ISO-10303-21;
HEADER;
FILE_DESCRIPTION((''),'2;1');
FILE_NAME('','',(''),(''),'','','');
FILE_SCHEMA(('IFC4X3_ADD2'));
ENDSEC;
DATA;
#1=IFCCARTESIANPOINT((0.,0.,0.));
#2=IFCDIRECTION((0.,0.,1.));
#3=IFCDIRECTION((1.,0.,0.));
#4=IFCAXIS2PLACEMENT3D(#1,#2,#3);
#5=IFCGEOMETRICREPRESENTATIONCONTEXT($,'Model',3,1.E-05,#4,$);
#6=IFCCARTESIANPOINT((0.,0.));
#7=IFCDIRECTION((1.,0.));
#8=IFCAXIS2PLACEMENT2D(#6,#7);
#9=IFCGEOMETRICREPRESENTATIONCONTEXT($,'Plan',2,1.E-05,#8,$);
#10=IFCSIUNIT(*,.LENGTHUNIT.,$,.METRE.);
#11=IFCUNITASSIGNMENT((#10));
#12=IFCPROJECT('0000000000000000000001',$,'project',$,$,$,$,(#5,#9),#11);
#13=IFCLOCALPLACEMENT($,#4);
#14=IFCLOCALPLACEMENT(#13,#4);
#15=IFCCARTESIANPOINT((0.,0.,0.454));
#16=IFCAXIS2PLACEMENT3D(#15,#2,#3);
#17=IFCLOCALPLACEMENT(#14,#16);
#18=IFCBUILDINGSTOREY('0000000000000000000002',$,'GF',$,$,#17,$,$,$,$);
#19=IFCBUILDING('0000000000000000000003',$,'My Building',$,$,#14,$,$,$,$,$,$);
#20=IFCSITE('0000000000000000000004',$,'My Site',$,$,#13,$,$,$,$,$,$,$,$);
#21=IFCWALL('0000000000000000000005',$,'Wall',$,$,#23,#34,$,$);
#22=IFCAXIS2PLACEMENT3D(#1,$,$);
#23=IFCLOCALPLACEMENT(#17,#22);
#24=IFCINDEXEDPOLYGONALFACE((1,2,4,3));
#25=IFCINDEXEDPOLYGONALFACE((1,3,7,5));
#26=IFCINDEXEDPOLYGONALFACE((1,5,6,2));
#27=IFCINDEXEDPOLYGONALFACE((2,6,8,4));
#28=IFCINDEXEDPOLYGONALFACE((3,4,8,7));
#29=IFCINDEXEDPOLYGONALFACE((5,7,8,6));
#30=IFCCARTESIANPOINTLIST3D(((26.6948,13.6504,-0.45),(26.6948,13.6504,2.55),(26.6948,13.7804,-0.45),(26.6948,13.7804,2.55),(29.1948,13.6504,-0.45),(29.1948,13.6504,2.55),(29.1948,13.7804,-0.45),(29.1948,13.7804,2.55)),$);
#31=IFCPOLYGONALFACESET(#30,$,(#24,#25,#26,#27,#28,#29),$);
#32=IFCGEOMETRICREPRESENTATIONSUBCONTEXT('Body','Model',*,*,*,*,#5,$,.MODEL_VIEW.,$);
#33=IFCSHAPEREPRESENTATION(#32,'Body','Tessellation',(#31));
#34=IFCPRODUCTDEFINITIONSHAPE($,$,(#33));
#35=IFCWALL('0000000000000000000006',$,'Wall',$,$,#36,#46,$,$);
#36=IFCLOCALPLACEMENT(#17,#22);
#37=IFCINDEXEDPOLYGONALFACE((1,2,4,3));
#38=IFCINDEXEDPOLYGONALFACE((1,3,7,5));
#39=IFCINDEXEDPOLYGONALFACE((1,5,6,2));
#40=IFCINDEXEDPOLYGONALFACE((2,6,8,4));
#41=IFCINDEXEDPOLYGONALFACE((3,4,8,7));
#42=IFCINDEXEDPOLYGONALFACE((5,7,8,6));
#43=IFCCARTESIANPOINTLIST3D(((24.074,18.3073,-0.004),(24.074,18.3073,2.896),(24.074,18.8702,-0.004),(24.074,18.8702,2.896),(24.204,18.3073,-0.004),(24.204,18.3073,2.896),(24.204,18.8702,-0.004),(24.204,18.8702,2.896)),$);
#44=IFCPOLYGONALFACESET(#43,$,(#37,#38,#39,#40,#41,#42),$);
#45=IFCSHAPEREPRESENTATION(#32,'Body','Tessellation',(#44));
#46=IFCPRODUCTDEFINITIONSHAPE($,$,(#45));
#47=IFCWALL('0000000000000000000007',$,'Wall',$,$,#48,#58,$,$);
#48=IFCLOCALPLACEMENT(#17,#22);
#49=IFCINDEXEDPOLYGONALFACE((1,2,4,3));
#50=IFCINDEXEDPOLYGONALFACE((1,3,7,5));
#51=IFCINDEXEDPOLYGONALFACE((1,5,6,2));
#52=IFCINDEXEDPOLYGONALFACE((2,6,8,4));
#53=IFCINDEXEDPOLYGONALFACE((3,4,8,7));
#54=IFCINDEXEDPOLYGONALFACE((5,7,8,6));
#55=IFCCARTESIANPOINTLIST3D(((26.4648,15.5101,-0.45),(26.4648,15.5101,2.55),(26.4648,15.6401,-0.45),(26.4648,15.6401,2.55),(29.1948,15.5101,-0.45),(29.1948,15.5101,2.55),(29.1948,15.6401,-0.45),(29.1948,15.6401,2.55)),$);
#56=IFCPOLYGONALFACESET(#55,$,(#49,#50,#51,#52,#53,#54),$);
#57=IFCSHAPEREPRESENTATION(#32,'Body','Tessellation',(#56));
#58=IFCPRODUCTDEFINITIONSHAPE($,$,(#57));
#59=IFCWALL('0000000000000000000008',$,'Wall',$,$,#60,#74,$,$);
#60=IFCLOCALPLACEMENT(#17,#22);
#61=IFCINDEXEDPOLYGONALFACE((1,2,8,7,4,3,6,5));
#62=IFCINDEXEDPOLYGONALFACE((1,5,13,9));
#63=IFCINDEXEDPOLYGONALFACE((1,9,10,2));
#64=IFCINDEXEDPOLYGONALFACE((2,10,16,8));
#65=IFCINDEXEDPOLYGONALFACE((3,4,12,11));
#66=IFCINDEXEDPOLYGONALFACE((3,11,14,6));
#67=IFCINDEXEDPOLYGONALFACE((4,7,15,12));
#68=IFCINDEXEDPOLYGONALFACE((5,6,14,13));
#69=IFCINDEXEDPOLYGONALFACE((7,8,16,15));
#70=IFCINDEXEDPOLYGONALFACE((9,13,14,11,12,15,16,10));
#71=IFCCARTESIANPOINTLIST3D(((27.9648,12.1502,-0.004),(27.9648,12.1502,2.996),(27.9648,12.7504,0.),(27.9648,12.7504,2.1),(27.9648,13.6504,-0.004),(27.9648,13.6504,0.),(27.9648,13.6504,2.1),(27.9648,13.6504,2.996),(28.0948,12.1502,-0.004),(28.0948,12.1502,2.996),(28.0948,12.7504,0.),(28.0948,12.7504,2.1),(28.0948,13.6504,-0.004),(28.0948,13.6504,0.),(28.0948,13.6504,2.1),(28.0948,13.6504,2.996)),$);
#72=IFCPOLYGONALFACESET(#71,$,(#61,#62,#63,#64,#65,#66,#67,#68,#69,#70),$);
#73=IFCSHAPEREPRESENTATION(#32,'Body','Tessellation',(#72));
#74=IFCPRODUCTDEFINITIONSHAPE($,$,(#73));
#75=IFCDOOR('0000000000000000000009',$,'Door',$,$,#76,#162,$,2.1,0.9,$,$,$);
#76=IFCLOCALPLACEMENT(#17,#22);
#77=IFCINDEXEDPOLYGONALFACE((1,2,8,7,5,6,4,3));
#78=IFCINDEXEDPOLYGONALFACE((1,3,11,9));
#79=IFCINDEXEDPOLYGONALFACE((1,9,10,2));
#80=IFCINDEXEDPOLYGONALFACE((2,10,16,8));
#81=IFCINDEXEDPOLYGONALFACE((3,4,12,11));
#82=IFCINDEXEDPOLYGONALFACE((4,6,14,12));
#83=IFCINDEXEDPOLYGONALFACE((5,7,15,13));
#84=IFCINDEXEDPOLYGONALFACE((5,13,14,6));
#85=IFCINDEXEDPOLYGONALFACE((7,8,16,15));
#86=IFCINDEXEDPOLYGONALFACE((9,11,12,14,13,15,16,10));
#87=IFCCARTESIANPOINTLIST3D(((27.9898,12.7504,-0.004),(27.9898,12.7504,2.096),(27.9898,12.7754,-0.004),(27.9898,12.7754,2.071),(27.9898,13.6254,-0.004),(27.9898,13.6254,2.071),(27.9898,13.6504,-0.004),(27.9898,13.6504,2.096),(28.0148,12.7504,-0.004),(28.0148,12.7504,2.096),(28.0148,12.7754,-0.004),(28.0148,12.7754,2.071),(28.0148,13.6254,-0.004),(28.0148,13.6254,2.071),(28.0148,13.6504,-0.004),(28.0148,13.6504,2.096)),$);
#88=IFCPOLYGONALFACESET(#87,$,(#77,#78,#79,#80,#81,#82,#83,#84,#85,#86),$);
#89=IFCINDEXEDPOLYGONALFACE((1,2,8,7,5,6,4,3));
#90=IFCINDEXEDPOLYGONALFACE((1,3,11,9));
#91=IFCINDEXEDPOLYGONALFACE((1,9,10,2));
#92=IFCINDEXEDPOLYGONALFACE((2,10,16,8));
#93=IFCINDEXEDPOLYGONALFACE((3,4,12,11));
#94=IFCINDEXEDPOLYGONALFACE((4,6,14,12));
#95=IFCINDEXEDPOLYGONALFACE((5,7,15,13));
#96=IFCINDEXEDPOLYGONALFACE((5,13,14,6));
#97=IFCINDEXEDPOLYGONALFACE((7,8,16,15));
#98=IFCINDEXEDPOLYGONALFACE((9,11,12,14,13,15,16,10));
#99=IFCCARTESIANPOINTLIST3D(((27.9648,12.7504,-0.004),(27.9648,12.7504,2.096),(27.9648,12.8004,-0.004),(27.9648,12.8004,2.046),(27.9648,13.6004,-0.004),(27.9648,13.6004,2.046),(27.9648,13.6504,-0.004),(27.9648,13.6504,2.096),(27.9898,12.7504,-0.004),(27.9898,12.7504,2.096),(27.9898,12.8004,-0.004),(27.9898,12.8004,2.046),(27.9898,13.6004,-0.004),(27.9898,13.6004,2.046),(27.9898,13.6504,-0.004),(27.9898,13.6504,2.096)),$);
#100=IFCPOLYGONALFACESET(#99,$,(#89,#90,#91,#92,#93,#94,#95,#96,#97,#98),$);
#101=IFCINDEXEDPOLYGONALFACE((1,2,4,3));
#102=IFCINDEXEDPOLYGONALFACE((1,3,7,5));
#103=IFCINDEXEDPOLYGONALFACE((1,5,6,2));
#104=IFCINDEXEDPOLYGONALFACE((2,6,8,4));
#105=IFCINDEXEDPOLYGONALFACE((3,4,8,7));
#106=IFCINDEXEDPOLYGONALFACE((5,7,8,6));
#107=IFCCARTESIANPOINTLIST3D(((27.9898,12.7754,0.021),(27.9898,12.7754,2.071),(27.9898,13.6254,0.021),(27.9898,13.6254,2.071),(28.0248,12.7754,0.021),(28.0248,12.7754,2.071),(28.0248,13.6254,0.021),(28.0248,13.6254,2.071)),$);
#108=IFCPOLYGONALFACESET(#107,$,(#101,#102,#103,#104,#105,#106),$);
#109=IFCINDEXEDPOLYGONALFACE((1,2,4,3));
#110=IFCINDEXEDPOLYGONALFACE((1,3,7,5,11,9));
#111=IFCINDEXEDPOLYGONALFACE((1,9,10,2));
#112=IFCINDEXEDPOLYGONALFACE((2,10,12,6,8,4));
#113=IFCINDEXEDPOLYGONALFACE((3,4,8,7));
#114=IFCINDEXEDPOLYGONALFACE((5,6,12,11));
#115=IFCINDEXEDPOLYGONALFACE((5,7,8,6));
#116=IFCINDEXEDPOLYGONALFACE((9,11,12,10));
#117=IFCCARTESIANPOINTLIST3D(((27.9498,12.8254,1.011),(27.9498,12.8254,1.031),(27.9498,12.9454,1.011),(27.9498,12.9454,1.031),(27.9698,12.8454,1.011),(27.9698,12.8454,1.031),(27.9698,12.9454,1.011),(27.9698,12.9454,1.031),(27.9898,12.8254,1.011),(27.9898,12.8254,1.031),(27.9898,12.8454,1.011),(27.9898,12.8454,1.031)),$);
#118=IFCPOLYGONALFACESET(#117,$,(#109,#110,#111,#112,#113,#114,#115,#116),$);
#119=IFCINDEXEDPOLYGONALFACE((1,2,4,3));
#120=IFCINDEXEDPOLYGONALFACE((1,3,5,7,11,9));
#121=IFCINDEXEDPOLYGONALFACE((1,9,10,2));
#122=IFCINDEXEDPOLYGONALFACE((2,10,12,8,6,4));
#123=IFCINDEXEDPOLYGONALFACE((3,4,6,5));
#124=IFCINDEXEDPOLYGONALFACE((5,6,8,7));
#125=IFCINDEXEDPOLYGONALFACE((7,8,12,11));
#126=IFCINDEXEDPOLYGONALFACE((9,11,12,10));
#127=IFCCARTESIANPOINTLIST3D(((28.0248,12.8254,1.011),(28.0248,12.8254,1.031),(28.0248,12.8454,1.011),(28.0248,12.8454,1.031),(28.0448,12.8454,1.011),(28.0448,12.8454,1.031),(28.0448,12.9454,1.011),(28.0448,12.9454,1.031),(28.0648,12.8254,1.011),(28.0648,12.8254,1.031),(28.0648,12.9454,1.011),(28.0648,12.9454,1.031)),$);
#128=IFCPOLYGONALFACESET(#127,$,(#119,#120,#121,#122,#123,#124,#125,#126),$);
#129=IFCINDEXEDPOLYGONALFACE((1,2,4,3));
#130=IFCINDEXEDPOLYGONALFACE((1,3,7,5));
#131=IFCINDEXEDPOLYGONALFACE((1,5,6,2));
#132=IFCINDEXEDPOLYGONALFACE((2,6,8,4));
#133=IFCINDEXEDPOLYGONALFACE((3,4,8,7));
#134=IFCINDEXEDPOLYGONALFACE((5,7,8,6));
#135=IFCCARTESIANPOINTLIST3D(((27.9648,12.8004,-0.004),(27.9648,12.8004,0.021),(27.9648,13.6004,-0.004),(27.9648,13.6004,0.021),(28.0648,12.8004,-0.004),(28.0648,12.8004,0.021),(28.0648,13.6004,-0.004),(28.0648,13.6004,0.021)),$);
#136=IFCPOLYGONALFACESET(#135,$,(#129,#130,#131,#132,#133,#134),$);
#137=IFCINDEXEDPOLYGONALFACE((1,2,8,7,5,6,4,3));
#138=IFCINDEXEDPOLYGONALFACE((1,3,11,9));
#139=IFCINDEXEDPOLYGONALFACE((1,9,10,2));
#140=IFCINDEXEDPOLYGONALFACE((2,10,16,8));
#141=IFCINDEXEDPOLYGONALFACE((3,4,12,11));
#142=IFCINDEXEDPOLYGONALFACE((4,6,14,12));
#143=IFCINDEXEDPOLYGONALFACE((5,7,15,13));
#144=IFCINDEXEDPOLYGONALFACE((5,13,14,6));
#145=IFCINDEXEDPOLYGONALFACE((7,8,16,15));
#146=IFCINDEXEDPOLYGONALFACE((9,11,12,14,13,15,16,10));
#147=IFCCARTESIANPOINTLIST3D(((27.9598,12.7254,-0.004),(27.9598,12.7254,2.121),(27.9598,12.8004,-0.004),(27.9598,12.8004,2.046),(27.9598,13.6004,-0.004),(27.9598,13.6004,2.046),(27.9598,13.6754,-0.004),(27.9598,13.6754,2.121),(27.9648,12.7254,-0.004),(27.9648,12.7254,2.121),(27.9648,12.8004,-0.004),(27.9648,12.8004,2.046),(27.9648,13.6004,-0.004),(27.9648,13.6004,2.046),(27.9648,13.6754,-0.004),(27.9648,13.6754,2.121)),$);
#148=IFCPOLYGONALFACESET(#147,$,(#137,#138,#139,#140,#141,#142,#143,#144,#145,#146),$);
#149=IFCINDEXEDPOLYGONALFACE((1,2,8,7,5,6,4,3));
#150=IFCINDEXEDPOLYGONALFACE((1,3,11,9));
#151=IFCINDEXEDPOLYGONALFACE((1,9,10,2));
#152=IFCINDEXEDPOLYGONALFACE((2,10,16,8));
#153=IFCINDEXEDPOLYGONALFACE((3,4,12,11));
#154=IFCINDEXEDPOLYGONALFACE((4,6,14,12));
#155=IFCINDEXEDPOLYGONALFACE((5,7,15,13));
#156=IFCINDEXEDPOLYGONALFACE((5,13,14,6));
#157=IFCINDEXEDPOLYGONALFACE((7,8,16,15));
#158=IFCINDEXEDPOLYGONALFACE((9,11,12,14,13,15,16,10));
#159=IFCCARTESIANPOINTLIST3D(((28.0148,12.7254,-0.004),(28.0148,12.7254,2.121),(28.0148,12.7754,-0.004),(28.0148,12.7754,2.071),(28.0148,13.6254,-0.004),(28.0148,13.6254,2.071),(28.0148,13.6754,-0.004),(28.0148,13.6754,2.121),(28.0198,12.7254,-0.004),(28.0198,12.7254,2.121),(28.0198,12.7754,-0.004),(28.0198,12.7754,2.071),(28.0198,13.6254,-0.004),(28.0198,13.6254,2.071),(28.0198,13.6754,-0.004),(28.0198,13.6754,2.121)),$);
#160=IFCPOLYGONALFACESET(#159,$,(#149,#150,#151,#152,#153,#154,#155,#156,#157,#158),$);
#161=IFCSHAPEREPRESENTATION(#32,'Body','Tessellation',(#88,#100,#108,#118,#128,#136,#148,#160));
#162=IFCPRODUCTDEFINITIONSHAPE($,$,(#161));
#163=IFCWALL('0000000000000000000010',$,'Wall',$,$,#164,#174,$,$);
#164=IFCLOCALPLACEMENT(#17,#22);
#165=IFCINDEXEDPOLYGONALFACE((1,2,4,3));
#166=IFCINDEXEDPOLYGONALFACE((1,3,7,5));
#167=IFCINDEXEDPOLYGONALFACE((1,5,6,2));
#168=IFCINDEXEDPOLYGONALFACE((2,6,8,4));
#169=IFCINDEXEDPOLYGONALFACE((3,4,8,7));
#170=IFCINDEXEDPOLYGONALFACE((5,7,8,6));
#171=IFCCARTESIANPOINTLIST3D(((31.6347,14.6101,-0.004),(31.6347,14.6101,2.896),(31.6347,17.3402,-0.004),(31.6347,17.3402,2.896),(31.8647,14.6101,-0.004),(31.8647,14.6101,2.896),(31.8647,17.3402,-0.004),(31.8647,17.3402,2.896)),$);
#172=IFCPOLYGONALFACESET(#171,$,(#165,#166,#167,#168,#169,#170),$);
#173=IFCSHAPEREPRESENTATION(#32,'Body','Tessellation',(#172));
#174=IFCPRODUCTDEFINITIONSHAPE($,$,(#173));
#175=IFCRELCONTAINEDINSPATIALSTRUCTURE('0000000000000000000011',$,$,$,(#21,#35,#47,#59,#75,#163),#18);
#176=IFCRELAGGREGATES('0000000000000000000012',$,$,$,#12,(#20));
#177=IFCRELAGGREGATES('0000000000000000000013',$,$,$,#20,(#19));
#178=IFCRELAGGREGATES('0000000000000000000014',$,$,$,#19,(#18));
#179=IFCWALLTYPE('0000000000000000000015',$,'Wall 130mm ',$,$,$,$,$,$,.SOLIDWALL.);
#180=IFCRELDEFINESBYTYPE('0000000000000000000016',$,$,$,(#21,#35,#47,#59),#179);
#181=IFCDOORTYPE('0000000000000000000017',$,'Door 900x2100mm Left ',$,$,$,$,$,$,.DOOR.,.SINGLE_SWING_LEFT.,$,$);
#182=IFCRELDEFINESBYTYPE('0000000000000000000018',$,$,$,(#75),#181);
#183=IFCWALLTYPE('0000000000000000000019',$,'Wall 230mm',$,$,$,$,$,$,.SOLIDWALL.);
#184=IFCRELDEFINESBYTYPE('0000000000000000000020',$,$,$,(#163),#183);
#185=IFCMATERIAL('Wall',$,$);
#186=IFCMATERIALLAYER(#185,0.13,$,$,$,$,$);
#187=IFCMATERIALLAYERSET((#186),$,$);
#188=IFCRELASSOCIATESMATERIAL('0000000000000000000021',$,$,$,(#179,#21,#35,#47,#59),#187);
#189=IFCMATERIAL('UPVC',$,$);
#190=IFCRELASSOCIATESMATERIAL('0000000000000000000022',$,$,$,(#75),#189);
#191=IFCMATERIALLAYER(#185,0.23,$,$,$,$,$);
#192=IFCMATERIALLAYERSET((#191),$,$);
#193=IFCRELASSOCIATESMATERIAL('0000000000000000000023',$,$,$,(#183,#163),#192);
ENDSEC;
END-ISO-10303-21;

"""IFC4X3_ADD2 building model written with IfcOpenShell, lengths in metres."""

from ifc_helpers import new_model, entity, si_unit, frame, origin_with_axes, origin_2d_with_axis, place, context, subcontext, project, spatial, line, indexed_curve, outline, extrude, shape, source, transform, mapped, material, layer, layer_set, layer_usage, type_object, type_shapes, element, fill, save


model = new_model("IFC4X3_ADD2")

# Units and contexts
model_context = context("Model", 3, precision=1e-05, world=origin_with_axes())
plan_context = context("Plan", 2, precision=1e-05, world=origin_2d_with_axis())
body_context_1 = subcontext(model_context, "Body", "Model", "MODEL_VIEW")
body_context_2 = subcontext(plan_context, "Body", "Plan", "PLAN_VIEW")
ifc_project = project(units=[si_unit("LENGTHUNIT", "METRE")], contexts=[model_context, plan_context])

# Site, building, storey
site_placement = place(None, origin_with_axes())
site = spatial("IfcSite", under=ifc_project, at=site_placement, Name="My Site")
building_placement = place(site_placement, origin_with_axes())
building = spatial("IfcBuilding", under=site, at=building_placement, Name="My Building")
storey_placement = place(building_placement, frame((0.0, 0.0, 0.454), z_axis=(0.0, 0.0, 1.0), x_axis=(1.0, 0.0, 0.0)))
storey = spatial("IfcBuildingStorey", under=building, at=storey_placement, Name="GF")

# Walls
ifc_material_1 = material(Name="Wall")
ifc_layer_1 = layer(ifc_material_1, 0.13)
ifc_layer_set_1 = layer_set([ifc_layer_1])
ifc_layer_usage_1 = layer_usage(ifc_layer_set_1, "AXIS2", "POSITIVE", 0.0)
wall_type_1 = type_object("IfcWallType", Name="Wall 130mm ", PredefinedType="SOLIDWALL", material=ifc_layer_set_1)
wall_1_placement = place(storey_placement, frame((29.1948, 13.7804, -0.45), z_axis=(0.0, 0.0, 1.0), x_axis=(-1.0, 0.0, 0.0)))
element("IfcWall", 1, at=wall_1_placement, inside=storey, type_object=wall_type_1, material=ifc_layer_usage_1, Name="Wall", context=body_context_1, shape_type="SweptSolid", body=[
    extrude(outline(indexed_curve([(0.0, 0.0), (0.0, 0.13), (2.5, 0.13), (2.5, 0.0), (0.0, 0.0)], self_intersect=False)), origin_with_axes(), (0.0, 0.0, 1.0), 3.0),
])
ifc_layer_usage_2 = layer_usage(ifc_layer_set_1, "AXIS2", "POSITIVE", 0.0)
wall_2_placement = place(storey_placement, frame((24.204, 18.3073, -0.004), z_axis=(0.0, 0.0, 1.0), x_axis=(0.000001, 1.0, 0.0)))
element("IfcWall", 2, at=wall_2_placement, inside=storey, type_object=wall_type_1, material=ifc_layer_usage_2, Name="Wall", context=body_context_1, shape_type="SweptSolid", body=[
    extrude(outline(indexed_curve([(0.0, 0.0), (0.0, 0.13), (0.5629, 0.13), (0.5629, 0.0), (0.0, 0.0)], self_intersect=False)), origin_with_axes(), (0.0, 0.0, 1.0), 2.9),
])
ifc_layer_usage_3 = layer_usage(ifc_layer_set_1, "AXIS2", "POSITIVE", 0.0)
wall_3_placement = place(storey_placement, frame((29.1948, 15.6401, -0.45), z_axis=(0.0, 0.0, 1.0), x_axis=(-1.0, 0.0, 0.0)))
element("IfcWall", 3, at=wall_3_placement, inside=storey, type_object=wall_type_1, material=ifc_layer_usage_3, Name="Wall", context=body_context_1, shape_type="SweptSolid", body=[
    extrude(outline(indexed_curve([(0.0, 0.0), (0.0, 0.13), (2.73, 0.13), (2.73, 0.0), (0.0, 0.0)], self_intersect=False)), origin_with_axes(), (0.0, 0.0, 1.0), 3.0),
])

# Wall, opening, door
ifc_layer_usage_4 = layer_usage(ifc_layer_set_1, "AXIS2", "POSITIVE", 0.0)
wall_4_placement = place(storey_placement, frame((27.9648, 13.6504, -0.004), z_axis=(0.0, 0.0, 1.0), x_axis=(0.0, -1.0, 0.0)))
wall_4 = element("IfcWall", 4, at=wall_4_placement, inside=storey, type_object=wall_type_1, material=ifc_layer_usage_4, Name="Wall", context=body_context_1, shape_type="SweptSolid", body=[
    extrude(outline(indexed_curve([(0.0, 0.0), (0.0, 0.13), (1.5002, 0.13), (1.5002, 0.0), (0.0, 0.0)], self_intersect=False)), origin_with_axes(), (0.0, 0.0, 1.0), 3.0),
])
shared_shape_1 = source(origin_with_axes(), body_context_1, "Body", "SweptSolid", [
    extrude(outline(indexed_curve([(0.0, 0.0), (0.9, 0.0), (0.9, 2.1), (0.0, 2.1)], segments=[line(1, 2, 3, 4, 1)])), frame((0.0, -0.6, 0.0), z_axis=(0.0, -1.0, 0.0), x_axis=(1.0, 0.0, 0.0)), (0.0, 0.0, -1.0), 1.2),
])
opening_1_placement = place(wall_4_placement, frame((0.0, 0.0, 0.004), z_axis=(0.0, 0.0, 1.0), x_axis=(1.0, 0.0, 0.0)))
opening_1 = element("IfcOpeningElement", 5, at=opening_1_placement, cuts=wall_4, PredefinedType="OPENING", context=body_context_1, shape_type="MappedRepresentation", body=[
    mapped(shared_shape_1, transform((0.0, 0.0, 0.0), x_axis=(1.0, 0.0, 0.0), y_axis=(0.0, 1.0, 0.0), z_axis=(0.0, 0.0, 1.0), scale=1.0)),
])
ifc_material_2 = material(Name="UPVC")
door_type_1 = type_object("IfcDoorType", Name="Door 900x2100mm Left ", OperationType="SINGLE_SWING_LEFT", PredefinedType="DOOR")
shared_shape_2 = source(origin_with_axes(), body_context_1, "Body", "SweptSolid", [
    extrude(outline(indexed_curve([(0.0, 0.0), (0.0, 2.1), (0.9, 2.1), (0.9, 0.0), (0.875, 0.0), (0.875, 2.075), (0.025, 2.075), (0.025, 0.0)], segments=[line(1, 2, 3, 4, 5, 6, 7, 8, 1)])), frame((0.0, 0.025, 0.0), z_axis=(0.0, -1.0, 0.0), x_axis=(1.0, 0.0, 0.0)), (0.0, 0.0, -1.0), 0.025),
    extrude(outline(indexed_curve([(0.0, 0.0), (0.0, 2.1), (0.9, 2.1), (0.9, 0.0), (0.85, 0.0), (0.85, 2.05), (0.05, 2.05), (0.05, 0.0)], segments=[line(1, 2, 3, 4, 5, 6, 7, 8, 1)])), frame((0.0, 0.0, 0.0), z_axis=(0.0, -1.0, 0.0), x_axis=(1.0, 0.0, 0.0)), (0.0, 0.0, -1.0), 0.025),
    extrude(outline(indexed_curve([(0.0, 0.0), (0.85, 0.0), (0.85, 0.035), (0.0, 0.035)], segments=[line(1, 2, 3, 4, 1)])), frame((0.025, 0.025, 0.025), z_axis=(0.0, 0.0, 1.0), x_axis=(1.0, 0.0, 0.0)), (0.0, 0.0, 1.0), 2.05),
    extrude(outline(indexed_curve([(0.0, 0.0), (0.0, -0.04), (-0.12, -0.04), (-0.12, -0.02), (-0.02, -0.02), (-0.02, 0.0)], segments=[line(1, 2, 3, 4, 5, 6, 1)])), frame((0.825, 0.025, 1.015), z_axis=(0.0, 0.0, 1.0), x_axis=(1.0, 0.0, 0.0)), (0.0, 0.0, 1.0), 0.02),
    extrude(outline(indexed_curve([(0.0, 0.0), (0.0, 0.04), (-0.12, 0.04), (-0.12, 0.02), (-0.02, 0.02), (-0.02, 0.0)], segments=[line(1, 2, 3, 4, 5, 6, 1)])), frame((0.825, 0.06, 1.015), z_axis=(0.0, 0.0, 1.0), x_axis=(1.0, 0.0, 0.0)), (0.0, 0.0, 1.0), 0.02),
    extrude(outline(indexed_curve([(0.0, 0.0), (0.8, 0.0), (0.8, 0.1), (0.0, 0.1)], segments=[line(1, 2, 3, 4, 1)])), frame((0.05, 0.0, 0.0), z_axis=(0.0, 0.0, 1.0), x_axis=(1.0, 0.0, 0.0)), (0.0, 0.0, 1.0), 0.025),
    extrude(outline(indexed_curve([(0.0, 0.0), (0.0, 2.125), (0.95, 2.125), (0.95, 0.0), (0.875, 0.0), (0.875, 2.05), (0.075, 2.05), (0.075, 0.0)], segments=[line(1, 2, 3, 4, 5, 6, 7, 8, 1)])), frame((-0.025, -0.005, 0.0), z_axis=(0.0, -1.0, 0.0), x_axis=(1.0, 0.0, 0.0)), (0.0, 0.0, -1.0), 0.005),
    extrude(outline(indexed_curve([(0.0, 0.0), (0.0, 2.125), (0.95, 2.125), (0.95, 0.0), (0.9, 0.0), (0.9, 2.075), (0.05, 2.075), (0.05, 0.0)], segments=[line(1, 2, 3, 4, 5, 6, 7, 8, 1)])), frame((-0.025, 0.05, 0.0), z_axis=(0.0, -1.0, 0.0), x_axis=(1.0, 0.0, 0.0)), (0.0, 0.0, -1.0), 0.005),
])
shared_shape_3 = source(origin_with_axes(), body_context_2, "Body", "Curve2D", [
    entity("IfcIndexedPolyCurve", entity("IfcCartesianPointList2D", [[0.0, 0.0], [0.0, 0.05], [0.025, 0.05], [0.025, 0.025], [0.05, 0.025], [0.05, 0.0]]), [entity("IfcLineIndex", [1, 2, 3, 4, 5, 6, 1])]),
    entity("IfcIndexedPolyCurve", entity("IfcCartesianPointList2D", [[0.9, 0.0], [0.9, 0.05], [0.875, 0.05], [0.875, 0.025], [0.85, 0.025], [0.85, 0.0]]), [entity("IfcLineIndex", [1, 2, 3, 4, 5, 6, 1])]),
    entity("IfcTrimmedCurve", entity("IfcEllipse", entity("IfcAxis2Placement2D", entity("IfcCartesianPoint", [0.06, 0.05]), entity("IfcDirection", [1.0, 0.0])), 0.815, 0.85), [entity("IfcCartesianPoint", [0.875, 0.05])], [entity("IfcCartesianPoint", [0.06, 0.9])], True, "CARTESIAN"),
    entity("IfcIndexedPolyCurve", entity("IfcCartesianPointList2D", [[0.025, 0.05], [0.06, 0.05], [0.06, 0.9], [0.025, 0.9]]), [entity("IfcLineIndex", [1, 2, 3, 4, 1])]),
])
type_shapes(door_type_1, [shared_shape_2, shared_shape_3])
door_1_placement = place(opening_1_placement, frame((0.0, 0.0, -0.004), z_axis=(0.0, 0.0, 1.0), x_axis=(1.0, 0.0, 0.0)))
door_1 = element("IfcDoor", 6, at=door_1_placement, inside=storey, type_object=door_type_1, material=ifc_material_2, Name="Door", OverallHeight=2.1, OverallWidth=0.9, shapes=[
    shape(body_context_1, "Body", "MappedRepresentation", [mapped(shared_shape_2, transform((0.0, 0.0, 0.0), x_axis=(1.0, 0.0, 0.0), y_axis=(0.0, 1.0, 0.0), z_axis=(0.0, 0.0, 1.0), scale=1.0))]),
    shape(body_context_2, "Body", "MappedRepresentation", [mapped(shared_shape_3, transform((0.0, 0.0, 0.0), x_axis=(1.0, 0.0, 0.0), y_axis=(0.0, 1.0, 0.0), z_axis=(0.0, 0.0, 1.0), scale=1.0))]),
])
fill(opening_1, door_1)

# Shared definitions
ifc_layer_2 = layer(ifc_material_1, 0.23)
ifc_layer_set_2 = layer_set([ifc_layer_2])
wall_type_2 = type_object("IfcWallType", Name="Wall 230mm", PredefinedType="SOLIDWALL", material=ifc_layer_set_2)

# Wall
ifc_layer_usage_5 = layer_usage(ifc_layer_set_2, "AXIS2", "POSITIVE", 0.0)
wall_5_placement = place(storey_placement, frame((31.8647, 14.6101, -0.004), z_axis=(0.0, 0.0, 1.0), x_axis=(0.000001, 1.0, 0.0)))
element("IfcWall", 7, at=wall_5_placement, inside=storey, type_object=wall_type_2, material=ifc_layer_usage_5, Name="Wall", context=body_context_1, shape_type="SweptSolid", body=[
    extrude(outline(indexed_curve([(0.0, 0.0), (0.0, 0.23), (2.73, 0.23), (2.73, 0.0), (0.0, 0.0)], self_intersect=False)), origin_with_axes(), (0.0, 0.0, 1.0), 2.9),
])

save(model, "model.ifc")
